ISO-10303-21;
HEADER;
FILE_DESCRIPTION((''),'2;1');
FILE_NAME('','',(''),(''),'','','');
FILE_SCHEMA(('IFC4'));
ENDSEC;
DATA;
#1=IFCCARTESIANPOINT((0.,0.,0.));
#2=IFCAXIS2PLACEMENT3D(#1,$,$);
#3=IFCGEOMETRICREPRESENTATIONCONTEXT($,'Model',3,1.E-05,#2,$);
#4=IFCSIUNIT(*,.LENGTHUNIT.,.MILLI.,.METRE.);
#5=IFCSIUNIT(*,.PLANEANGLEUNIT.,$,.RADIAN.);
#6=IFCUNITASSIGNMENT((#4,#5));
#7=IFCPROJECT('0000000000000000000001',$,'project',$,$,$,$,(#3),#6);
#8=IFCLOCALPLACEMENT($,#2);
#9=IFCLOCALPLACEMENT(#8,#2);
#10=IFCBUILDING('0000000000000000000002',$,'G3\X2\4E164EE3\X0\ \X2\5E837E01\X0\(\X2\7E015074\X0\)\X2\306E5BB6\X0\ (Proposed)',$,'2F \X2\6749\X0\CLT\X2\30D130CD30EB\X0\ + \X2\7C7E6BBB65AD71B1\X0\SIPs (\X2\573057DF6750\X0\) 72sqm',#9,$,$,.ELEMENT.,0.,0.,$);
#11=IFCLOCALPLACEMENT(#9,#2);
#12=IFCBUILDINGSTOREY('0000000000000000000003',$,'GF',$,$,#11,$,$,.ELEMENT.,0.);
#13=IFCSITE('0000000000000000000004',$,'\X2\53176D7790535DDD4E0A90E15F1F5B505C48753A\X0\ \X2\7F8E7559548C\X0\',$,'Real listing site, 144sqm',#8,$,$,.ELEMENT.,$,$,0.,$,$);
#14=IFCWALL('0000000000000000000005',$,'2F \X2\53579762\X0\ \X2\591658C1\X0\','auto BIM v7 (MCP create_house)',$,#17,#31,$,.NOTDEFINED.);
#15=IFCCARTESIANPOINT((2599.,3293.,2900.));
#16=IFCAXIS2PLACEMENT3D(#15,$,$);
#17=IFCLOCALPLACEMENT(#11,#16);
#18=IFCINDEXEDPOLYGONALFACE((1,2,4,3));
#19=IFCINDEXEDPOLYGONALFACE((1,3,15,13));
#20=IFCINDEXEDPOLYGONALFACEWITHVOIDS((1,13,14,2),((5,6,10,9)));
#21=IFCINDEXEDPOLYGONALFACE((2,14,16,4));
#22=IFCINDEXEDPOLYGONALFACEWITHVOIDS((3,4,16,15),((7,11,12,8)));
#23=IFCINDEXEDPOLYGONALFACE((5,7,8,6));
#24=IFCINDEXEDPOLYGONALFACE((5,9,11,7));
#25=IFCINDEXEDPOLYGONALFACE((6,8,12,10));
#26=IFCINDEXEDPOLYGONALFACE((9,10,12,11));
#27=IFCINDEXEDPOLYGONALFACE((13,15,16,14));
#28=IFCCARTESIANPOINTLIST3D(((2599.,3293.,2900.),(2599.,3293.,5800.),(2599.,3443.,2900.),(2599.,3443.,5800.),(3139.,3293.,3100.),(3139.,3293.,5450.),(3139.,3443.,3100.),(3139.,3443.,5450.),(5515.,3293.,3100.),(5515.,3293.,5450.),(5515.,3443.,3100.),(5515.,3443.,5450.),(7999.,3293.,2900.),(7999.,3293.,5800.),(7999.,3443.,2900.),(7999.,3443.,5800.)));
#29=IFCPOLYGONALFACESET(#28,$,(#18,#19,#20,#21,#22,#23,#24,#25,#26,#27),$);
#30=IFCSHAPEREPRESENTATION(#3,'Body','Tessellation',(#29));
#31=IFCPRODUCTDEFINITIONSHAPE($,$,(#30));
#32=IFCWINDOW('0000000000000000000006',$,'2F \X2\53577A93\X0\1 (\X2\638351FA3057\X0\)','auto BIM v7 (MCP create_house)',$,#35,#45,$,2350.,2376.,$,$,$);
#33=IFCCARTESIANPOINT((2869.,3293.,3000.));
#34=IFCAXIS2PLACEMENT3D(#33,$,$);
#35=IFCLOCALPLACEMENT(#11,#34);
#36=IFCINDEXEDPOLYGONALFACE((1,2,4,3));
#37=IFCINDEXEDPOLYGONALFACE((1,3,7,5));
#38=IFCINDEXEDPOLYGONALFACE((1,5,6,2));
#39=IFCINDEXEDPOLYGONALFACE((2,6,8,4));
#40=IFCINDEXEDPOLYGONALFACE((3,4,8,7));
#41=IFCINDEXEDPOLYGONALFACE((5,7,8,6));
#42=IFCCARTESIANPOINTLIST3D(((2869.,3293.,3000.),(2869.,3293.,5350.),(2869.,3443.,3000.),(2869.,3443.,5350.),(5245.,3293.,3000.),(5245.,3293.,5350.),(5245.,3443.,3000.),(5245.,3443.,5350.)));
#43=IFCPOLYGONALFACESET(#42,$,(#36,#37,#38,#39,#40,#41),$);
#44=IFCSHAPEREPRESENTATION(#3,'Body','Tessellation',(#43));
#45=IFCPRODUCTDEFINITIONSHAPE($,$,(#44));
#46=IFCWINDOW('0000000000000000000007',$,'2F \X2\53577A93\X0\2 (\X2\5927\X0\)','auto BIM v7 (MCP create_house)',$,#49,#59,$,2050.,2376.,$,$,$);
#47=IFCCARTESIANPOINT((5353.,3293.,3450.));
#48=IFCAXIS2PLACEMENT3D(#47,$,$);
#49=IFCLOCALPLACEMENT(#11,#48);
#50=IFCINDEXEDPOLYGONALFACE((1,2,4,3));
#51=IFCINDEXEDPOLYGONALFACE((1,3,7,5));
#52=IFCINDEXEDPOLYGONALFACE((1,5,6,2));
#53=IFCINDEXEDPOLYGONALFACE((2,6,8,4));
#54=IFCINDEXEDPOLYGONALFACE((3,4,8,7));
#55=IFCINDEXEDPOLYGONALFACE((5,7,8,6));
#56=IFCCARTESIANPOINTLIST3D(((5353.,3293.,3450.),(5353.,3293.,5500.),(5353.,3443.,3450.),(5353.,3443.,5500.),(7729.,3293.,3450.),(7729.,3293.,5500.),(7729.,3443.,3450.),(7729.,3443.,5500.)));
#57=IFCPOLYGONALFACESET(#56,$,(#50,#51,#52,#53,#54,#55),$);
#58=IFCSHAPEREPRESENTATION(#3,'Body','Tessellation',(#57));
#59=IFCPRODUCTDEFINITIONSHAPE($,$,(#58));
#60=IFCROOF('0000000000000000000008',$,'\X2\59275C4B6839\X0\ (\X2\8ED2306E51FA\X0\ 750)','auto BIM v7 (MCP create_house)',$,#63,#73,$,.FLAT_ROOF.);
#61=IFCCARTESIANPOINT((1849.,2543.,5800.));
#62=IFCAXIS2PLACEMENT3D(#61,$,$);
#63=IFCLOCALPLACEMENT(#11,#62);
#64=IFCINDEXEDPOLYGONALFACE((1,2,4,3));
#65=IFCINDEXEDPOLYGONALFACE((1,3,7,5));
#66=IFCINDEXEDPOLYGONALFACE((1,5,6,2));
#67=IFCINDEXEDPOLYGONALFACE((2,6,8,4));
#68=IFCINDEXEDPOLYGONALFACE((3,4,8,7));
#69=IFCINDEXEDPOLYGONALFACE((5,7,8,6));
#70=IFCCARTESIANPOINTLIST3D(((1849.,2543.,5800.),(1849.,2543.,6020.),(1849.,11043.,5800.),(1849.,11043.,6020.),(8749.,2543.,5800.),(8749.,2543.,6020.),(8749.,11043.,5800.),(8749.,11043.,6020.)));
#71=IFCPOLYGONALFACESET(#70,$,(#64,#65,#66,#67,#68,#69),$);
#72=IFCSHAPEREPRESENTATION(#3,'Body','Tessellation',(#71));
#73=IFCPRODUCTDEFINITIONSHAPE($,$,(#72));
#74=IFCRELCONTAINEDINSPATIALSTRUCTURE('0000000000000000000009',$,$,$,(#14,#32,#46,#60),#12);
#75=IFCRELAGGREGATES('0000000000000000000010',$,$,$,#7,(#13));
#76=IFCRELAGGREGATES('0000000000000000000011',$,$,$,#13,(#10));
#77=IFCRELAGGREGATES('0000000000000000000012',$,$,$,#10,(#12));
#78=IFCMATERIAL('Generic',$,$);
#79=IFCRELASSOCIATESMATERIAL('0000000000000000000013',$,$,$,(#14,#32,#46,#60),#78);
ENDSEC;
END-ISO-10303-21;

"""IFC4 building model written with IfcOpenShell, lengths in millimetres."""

from ifc_helpers import new_model, si_unit, frame, frame_2d, origin, place, context, project, spatial, rectangle, extrude, material, element, fill, save


model = new_model("IFC4")

# Units and contexts
model_context = context("Model", 3, precision=1e-05, world=origin())
ifc_project = project(units=[si_unit("LENGTHUNIT", "METRE", prefix="MILLI"), si_unit("PLANEANGLEUNIT", "RADIAN")], contexts=[model_context])

# Site, building, storey
site_placement = place(None, origin())
site = spatial("IfcSite", under=ifc_project, at=site_placement, Name="北海道川上郡弟子屈町 美留和", ObjectType="Real listing site, 144sqm", CompositionType="ELEMENT", RefElevation=0.0)
building_placement = place(site_placement, origin())
building = spatial("IfcBuilding", under=site, at=building_placement, Name="G3世代 広縁(縁側)の家 (Proposed)", ObjectType="2F 杉CLTパネル + 籾殻断熱SIPs (地域材) 72sqm", CompositionType="ELEMENT", ElevationOfRefHeight=0.0, ElevationOfTerrain=0.0)
storey_placement = place(building_placement, origin())
storey = spatial("IfcBuildingStorey", under=building, at=storey_placement, Name="GF", CompositionType="ELEMENT", Elevation=0.0)

# Shared definitions
ifc_material = material(Name="Generic")

# Wall, openings, windows
wall_1_placement = place(storey_placement, frame((2599.0, 3293.0, 2900.0)))
wall_1 = element("IfcWall", 1, at=wall_1_placement, inside=storey, material=ifc_material, Name="2F 南面 外壁", Description="auto BIM v7 (MCP create_house)", PredefinedType="NOTDEFINED", context=model_context, shape_type="SweptSolid", body=[
    extrude(rectangle(XDim=5400.0, YDim=150.0, at=frame_2d((2700.0, 75.0))), frame((2599.0, 3293.0, 2900.0)), (0.0, 0.0, 1.0), 2900.0),
])
opening_1_placement = place(storey_placement, frame((2869.0, 3293.0, 3000.0)))
opening_1 = element("IfcOpeningElement", 2, at=opening_1_placement, cuts=wall_1, PredefinedType="NOTDEFINED", context=model_context, shape_type="SweptSolid", body=[
    extrude(rectangle(XDim=2376.0, YDim=150.0, at=frame_2d((1188.0, 75.0))), frame((2869.0, 3293.0, 3000.0)), (0.0, 0.0, 1.0), 2350.0),
])
opening_2_placement = place(storey_placement, frame((5353.0, 3293.0, 3450.0)))
opening_2 = element("IfcOpeningElement", 3, at=opening_2_placement, cuts=wall_1, PredefinedType="NOTDEFINED", context=model_context, shape_type="SweptSolid", body=[
    extrude(rectangle(XDim=2376.0, YDim=150.0, at=frame_2d((1188.0, 75.0))), frame((5353.0, 3293.0, 3450.0)), (0.0, 0.0, 1.0), 2050.0),
])
window_1_placement = place(storey_placement, frame((2869.0, 3293.0, 3000.0)))
window_1 = element("IfcWindow", 4, at=window_1_placement, inside=storey, material=ifc_material, Name="2F 南窓1 (掃出し)", Description="auto BIM v7 (MCP create_house)", OverallHeight=2350.0, OverallWidth=2376.0, context=model_context, shape_type="SweptSolid", body=[
    extrude(rectangle(XDim=2376.0, YDim=150.0, at=frame_2d((1188.0, 75.0))), frame((2869.0, 3293.0, 3000.0)), (0.0, 0.0, 1.0), 2350.0),
])
fill(opening_1, window_1)
window_2_placement = place(storey_placement, frame((5353.0, 3293.0, 3450.0)))
window_2 = element("IfcWindow", 5, at=window_2_placement, inside=storey, material=ifc_material, Name="2F 南窓2 (大)", Description="auto BIM v7 (MCP create_house)", OverallHeight=2050.0, OverallWidth=2376.0, context=model_context, shape_type="SweptSolid", body=[
    extrude(rectangle(XDim=2376.0, YDim=150.0, at=frame_2d((1188.0, 75.0))), frame((5353.0, 3293.0, 3450.0)), (0.0, 0.0, 1.0), 2050.0),
])
fill(opening_2, window_2)

# Roof
roof_placement = place(storey_placement, frame((1849.0, 2543.0, 5800.0)))
element("IfcRoof", 6, at=roof_placement, inside=storey, material=ifc_material, Name="大屋根 (軒の出 750)", Description="auto BIM v7 (MCP create_house)", PredefinedType="FLAT_ROOF", context=model_context, shape_type="SweptSolid", body=[
    extrude(rectangle(XDim=6900.0, YDim=8500.0, at=frame_2d((3450.0, 4250.0))), frame((1849.0, 2543.0, 5800.0)), (0.0, 0.0, 1.0), 220.0),
])

save(model, "model.ifc")
